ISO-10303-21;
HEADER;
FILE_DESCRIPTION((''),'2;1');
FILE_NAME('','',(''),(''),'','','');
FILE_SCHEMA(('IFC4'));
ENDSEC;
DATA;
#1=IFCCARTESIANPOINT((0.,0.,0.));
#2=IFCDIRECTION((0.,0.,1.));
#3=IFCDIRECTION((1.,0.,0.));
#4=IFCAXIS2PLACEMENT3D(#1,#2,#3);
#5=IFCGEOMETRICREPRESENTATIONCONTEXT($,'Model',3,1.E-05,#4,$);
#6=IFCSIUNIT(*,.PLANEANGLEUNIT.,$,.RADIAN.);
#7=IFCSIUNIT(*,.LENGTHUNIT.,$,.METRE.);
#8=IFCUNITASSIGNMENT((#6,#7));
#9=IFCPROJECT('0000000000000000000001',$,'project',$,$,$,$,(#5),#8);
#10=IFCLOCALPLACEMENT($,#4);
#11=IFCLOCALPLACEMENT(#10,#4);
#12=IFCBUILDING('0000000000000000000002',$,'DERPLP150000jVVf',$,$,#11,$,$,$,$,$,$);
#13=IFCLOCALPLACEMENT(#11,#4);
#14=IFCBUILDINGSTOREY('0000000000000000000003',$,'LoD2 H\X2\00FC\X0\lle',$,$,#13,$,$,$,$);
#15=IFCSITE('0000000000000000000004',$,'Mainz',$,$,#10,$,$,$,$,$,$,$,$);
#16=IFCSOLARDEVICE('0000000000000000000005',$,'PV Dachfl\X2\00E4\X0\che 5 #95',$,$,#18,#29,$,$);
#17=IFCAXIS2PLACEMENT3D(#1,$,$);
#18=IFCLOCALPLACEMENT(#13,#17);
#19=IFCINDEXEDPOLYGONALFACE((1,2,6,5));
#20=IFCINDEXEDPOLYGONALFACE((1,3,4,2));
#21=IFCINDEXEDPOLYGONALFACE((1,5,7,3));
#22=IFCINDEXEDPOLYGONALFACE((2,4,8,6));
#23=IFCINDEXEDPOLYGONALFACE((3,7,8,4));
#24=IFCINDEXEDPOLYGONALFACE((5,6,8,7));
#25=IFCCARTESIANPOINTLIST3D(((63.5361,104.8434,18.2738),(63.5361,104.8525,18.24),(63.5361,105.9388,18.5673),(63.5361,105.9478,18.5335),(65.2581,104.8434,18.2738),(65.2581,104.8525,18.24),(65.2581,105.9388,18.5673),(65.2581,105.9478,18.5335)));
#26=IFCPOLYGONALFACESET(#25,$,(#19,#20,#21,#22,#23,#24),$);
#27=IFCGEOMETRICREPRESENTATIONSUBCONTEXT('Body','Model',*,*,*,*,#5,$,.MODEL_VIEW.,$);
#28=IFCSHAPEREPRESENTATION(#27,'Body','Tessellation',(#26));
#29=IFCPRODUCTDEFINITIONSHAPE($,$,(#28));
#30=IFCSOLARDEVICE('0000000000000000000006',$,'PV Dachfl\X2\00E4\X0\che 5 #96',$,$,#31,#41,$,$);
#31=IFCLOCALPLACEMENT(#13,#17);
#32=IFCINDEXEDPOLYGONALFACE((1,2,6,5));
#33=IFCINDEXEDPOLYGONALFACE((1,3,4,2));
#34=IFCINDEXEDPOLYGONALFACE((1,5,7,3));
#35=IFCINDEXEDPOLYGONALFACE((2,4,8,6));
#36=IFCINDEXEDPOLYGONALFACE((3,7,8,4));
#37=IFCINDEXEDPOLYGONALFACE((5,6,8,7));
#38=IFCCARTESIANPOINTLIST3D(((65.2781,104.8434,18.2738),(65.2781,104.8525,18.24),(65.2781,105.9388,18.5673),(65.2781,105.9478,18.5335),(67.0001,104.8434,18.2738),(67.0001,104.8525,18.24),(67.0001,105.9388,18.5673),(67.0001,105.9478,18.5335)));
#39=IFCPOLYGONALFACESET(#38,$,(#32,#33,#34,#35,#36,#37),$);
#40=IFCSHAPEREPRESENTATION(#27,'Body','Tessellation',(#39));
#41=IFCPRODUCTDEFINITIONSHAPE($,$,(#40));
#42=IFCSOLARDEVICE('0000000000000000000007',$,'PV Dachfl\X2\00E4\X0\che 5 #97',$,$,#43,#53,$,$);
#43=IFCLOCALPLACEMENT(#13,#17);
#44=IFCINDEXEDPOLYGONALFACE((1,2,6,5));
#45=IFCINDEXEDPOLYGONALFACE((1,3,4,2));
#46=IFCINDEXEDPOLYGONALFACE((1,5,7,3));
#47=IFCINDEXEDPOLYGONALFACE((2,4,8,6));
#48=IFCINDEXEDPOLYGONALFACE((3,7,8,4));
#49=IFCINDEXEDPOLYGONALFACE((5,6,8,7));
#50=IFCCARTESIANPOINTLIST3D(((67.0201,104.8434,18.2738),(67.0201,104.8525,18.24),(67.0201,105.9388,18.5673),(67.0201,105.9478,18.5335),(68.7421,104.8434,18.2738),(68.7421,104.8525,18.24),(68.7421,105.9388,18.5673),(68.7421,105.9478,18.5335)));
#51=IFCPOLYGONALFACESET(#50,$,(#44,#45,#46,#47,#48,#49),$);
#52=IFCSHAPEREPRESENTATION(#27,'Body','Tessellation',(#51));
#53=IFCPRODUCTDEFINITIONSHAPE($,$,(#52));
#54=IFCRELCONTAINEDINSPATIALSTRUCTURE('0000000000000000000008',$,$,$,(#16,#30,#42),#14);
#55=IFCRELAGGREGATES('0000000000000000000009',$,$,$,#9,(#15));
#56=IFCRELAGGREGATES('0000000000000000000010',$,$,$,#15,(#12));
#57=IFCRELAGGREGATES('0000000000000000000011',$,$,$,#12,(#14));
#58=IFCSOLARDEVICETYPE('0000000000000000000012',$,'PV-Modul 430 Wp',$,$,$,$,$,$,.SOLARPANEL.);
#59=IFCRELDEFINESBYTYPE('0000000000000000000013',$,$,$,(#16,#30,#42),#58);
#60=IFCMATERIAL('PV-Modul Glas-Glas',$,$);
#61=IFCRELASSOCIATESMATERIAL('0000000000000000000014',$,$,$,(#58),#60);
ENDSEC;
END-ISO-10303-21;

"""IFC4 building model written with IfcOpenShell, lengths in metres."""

from ifc_helpers import new_model, si_unit, frame, frame_2d, origin, origin_with_axes, place, context, subcontext, project, spatial, rectangle, extrude, source, transform, mapped, material, type_object, type_shapes, element, save


model = new_model("IFC4")

# Units and contexts
model_context = context("Model", 3, precision=1e-05, world=origin_with_axes())
body_context = subcontext(model_context, "Body", "Model", "MODEL_VIEW")
ifc_project = project(units=[si_unit("PLANEANGLEUNIT", "RADIAN"), si_unit("LENGTHUNIT", "METRE")], contexts=[model_context])

# Site, building, storey
site_placement = place(None, origin_with_axes())
site = spatial("IfcSite", under=ifc_project, at=site_placement, Name="Mainz")
building_placement = place(site_placement, origin_with_axes())
building = spatial("IfcBuilding", under=site, at=building_placement, Name="DERPLP150000jVVf")
storey_placement = place(building_placement, origin_with_axes())
storey = spatial("IfcBuildingStorey", under=building, at=storey_placement, Name="LoD2 Hülle")

# Solar devices
ifc_material = material(Name="PV-Modul Glas-Glas")
solar_device_type = type_object("IfcSolarDeviceType", Name="PV-Modul 430 Wp", PredefinedType="SOLARPANEL", material=ifc_material)
shared_shape = source(origin_with_axes(), body_context, "Body", "SweptSolid", [
    extrude(rectangle(XDim=1.722, YDim=1.134, at=frame_2d((0.861, 0.567))), origin(), (0.0, 0.0, 1.0), 0.035),
])
type_shapes(solar_device_type, [shared_shape])
for number, where, z_axis, x_axis, name in (
    (1, (63.5361, 104.8525, 18.24), (0.0, -0.258819, 0.965926), (1.0, 0.0, 0.0), "PV Dachfläche 5 #95"),
    (2, (65.2781, 104.8525, 18.24), (0.0, -0.258819, 0.965926), (1.0, 0.0, 0.0), "PV Dachfläche 5 #96"),
    (3, (67.0201, 104.8525, 18.24), (0.0, -0.258819, 0.965926), (1.0, 0.0, 0.0), "PV Dachfläche 5 #97"),
):
    element("IfcSolarDevice", number, at=place(storey_placement, frame(where, z_axis=z_axis, x_axis=x_axis)), inside=storey, type_object=solar_device_type, Name=name, context=body_context, shape_type="MappedRepresentation", body=[
        mapped(shared_shape, transform((0.0, 0.0, 0.0), x_axis=(1.0, 0.0, 0.0), y_axis=(0.0, 1.0, 0.0), z_axis=(0.0, 0.0, 1.0), scale=1.0)),
    ])

save(model, "model.ifc")
